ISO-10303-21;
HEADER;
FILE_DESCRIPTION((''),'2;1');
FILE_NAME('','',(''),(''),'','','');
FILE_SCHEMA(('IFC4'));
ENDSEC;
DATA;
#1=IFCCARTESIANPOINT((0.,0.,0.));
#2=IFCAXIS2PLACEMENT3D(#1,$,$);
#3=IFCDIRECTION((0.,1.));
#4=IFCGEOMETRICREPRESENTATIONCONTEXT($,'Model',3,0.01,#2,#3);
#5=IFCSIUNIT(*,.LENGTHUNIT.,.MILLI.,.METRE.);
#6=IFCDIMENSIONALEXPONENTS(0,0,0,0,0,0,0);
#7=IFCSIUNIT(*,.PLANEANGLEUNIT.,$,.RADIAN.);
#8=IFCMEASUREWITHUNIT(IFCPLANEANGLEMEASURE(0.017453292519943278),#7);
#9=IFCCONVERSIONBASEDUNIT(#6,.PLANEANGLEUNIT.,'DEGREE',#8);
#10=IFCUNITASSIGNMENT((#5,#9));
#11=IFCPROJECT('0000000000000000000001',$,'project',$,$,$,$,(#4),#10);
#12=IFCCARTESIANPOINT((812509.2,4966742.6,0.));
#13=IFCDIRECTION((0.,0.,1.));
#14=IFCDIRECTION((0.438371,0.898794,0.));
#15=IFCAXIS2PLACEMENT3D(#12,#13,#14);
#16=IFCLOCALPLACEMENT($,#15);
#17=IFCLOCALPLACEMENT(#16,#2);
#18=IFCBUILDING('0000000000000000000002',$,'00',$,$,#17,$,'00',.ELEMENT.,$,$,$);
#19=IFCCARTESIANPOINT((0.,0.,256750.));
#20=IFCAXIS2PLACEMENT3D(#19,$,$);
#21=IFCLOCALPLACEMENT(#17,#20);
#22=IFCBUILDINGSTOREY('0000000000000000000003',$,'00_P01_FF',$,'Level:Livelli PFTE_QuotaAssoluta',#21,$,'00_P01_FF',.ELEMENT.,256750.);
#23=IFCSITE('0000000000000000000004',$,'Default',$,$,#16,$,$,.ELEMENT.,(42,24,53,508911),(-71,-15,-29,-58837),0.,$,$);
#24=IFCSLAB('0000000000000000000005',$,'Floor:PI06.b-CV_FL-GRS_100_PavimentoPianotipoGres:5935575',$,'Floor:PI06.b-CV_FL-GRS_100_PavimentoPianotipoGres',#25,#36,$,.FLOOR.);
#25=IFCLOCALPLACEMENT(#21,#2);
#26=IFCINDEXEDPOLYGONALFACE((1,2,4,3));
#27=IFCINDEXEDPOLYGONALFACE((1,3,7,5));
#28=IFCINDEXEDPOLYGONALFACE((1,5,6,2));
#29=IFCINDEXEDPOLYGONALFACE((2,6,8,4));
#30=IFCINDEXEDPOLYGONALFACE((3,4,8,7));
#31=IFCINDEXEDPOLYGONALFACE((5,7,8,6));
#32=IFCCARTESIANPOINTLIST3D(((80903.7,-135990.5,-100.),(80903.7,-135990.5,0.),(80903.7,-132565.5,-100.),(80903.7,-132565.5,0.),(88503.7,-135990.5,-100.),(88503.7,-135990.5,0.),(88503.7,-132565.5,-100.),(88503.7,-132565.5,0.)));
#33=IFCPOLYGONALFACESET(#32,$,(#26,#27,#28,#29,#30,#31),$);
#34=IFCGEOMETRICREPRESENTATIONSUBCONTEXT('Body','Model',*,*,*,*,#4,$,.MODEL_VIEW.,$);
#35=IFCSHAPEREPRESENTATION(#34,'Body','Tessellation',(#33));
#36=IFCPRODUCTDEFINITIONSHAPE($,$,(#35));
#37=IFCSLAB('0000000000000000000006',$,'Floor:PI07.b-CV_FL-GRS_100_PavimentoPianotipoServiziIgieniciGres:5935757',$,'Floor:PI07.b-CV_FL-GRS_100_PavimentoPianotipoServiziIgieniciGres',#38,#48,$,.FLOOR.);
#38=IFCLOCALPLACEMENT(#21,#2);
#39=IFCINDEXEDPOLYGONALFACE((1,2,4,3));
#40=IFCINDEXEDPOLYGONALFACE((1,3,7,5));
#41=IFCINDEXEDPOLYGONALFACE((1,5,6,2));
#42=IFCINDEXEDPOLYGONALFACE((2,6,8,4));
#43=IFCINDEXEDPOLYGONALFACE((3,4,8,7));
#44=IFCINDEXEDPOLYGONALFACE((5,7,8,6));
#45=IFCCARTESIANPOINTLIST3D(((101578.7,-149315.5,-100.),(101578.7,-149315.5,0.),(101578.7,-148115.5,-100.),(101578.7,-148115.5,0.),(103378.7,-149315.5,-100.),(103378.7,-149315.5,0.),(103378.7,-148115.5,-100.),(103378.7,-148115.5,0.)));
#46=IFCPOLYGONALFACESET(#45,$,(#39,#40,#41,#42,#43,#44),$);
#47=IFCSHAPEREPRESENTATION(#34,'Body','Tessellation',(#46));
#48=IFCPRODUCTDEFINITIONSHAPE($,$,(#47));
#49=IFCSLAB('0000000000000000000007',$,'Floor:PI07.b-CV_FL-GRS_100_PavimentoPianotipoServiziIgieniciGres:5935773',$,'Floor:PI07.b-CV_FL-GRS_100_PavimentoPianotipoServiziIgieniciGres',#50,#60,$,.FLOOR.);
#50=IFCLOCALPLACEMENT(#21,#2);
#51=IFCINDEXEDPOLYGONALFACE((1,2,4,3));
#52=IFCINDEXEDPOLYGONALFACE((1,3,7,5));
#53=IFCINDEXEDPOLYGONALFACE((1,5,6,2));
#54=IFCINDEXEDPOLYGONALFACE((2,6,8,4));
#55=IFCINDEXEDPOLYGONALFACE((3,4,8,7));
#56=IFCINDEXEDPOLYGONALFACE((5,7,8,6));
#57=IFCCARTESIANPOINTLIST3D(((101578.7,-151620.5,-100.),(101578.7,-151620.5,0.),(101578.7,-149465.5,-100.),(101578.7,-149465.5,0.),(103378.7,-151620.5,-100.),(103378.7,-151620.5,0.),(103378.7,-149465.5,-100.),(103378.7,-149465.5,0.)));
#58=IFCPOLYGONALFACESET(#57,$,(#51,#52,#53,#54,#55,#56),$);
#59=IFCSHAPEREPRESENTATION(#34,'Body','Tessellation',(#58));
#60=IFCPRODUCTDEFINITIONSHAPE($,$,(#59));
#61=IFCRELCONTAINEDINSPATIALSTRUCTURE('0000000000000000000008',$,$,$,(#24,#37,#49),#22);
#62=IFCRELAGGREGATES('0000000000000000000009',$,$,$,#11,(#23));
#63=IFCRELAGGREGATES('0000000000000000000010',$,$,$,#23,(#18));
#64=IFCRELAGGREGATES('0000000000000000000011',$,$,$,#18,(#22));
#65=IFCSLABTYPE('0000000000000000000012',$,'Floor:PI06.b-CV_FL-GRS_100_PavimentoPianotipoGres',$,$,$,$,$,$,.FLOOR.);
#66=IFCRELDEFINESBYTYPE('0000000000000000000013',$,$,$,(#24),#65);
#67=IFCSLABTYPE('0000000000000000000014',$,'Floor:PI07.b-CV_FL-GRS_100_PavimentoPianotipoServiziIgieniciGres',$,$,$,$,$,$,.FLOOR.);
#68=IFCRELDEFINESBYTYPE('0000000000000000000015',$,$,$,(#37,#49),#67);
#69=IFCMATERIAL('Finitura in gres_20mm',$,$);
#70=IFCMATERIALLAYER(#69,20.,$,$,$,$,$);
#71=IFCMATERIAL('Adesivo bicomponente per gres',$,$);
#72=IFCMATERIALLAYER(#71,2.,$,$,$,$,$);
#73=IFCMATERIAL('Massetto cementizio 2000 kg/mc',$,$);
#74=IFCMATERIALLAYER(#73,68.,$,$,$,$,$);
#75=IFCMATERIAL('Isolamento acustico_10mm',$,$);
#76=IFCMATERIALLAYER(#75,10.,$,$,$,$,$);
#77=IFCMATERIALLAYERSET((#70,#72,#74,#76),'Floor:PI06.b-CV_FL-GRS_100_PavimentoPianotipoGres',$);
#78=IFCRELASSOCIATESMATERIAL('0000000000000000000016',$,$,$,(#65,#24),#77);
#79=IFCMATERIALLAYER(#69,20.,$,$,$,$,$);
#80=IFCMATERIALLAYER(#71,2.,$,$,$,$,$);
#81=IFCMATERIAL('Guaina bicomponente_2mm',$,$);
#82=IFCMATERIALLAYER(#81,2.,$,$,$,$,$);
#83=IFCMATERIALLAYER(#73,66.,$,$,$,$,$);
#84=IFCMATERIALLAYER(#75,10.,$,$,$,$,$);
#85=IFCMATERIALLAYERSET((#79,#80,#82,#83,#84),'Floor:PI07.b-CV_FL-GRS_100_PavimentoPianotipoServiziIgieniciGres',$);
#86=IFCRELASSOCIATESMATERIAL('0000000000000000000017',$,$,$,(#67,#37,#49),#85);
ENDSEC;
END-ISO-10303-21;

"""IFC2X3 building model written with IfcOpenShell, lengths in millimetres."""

from ifc_helpers import new_model, entity, si_unit, converted_unit, direction, frame, frame_2d, origin, place, context, subcontext, project, spatial, rectangle, extrude, material, layer, layer_set, layer_usage, type_object, element, save


model = new_model("IFC2X3")

# Units and contexts
model_context = context("Model", 3, precision=0.01, world=origin(), true_north=direction((0.0, 1.0)))
body_context = subcontext(model_context, "Body", "Model", "MODEL_VIEW")
ifc_project = project(units=[si_unit("LENGTHUNIT", "METRE", prefix="MILLI"), converted_unit("PLANEANGLEUNIT", "DEGREE", entity("IfcPlaneAngleMeasure", 0.017453292519943278), si_unit("PLANEANGLEUNIT", "RADIAN"), dimensions=[0, 0, 0, 0, 0, 0, 0])], contexts=[model_context])

# Site, building, storey
site_placement = place(None, frame((812509.2, 4966742.6, 0.0), z_axis=(0.0, 0.0, 1.0), x_axis=(0.438371, 0.898794, 0.0)))
site = spatial("IfcSite", under=ifc_project, at=site_placement, Name="Default", CompositionType="ELEMENT", RefLatitude=(42, 24, 53, 508911), RefLongitude=(-71, -15, -29, -58837), RefElevation=0.0)
building_placement = place(site_placement, origin())
building = spatial("IfcBuilding", under=site, at=building_placement, Name="00", LongName="00", CompositionType="ELEMENT")
storey_placement = place(building_placement, frame((0.0, 0.0, 256750.0)))
storey = spatial("IfcBuildingStorey", under=building, at=storey_placement, Name="00_P01_FF", ObjectType="Level:Livelli PFTE_QuotaAssoluta", LongName="00_P01_FF", CompositionType="ELEMENT", Elevation=256750.0)

# Slab
ifc_material_1 = material(Name="Finitura in gres_20mm")
ifc_layer_1 = layer(ifc_material_1, 20.0)
ifc_material_2 = material(Name="Adesivo bicomponente per gres")
ifc_layer_2 = layer(ifc_material_2, 2.0)
ifc_material_3 = material(Name="Massetto cementizio 2000 kg/mc")
ifc_layer_3 = layer(ifc_material_3, 68.0)
ifc_material_4 = material(Name="Isolamento acustico_10mm")
ifc_layer_4 = layer(ifc_material_4, 10.0)
ifc_layer_set_1 = layer_set([ifc_layer_1, ifc_layer_2, ifc_layer_3, ifc_layer_4], Name="Floor:PI06.b-CV_FL-GRS_100_PavimentoPianotipoGres")
slab_type_1 = type_object("IfcSlabType", Name="Floor:PI06.b-CV_FL-GRS_100_PavimentoPianotipoGres", PredefinedType="FLOOR", material=ifc_layer_set_1)
ifc_layer_usage_1 = layer_usage(ifc_layer_set_1, "AXIS3", "POSITIVE", 0.0)
slab_1_placement = place(storey_placement, origin())
element("IfcSlab", 1, at=slab_1_placement, inside=storey, type_object=slab_type_1, material=ifc_layer_usage_1, Name="Floor:PI06.b-CV_FL-GRS_100_PavimentoPianotipoGres:5935575", ObjectType="Floor:PI06.b-CV_FL-GRS_100_PavimentoPianotipoGres", PredefinedType="FLOOR", context=body_context, shape_type="SweptSolid", body=[
    extrude(rectangle(XDim=7600.0, YDim=3425.0, at=frame_2d((0.0, 0.0), x_axis=(1.0, 0.0))), frame((84703.7, -134278.0, 0.0), z_axis=(0.0, 0.0, -1.0), x_axis=(1.0, 0.0, 0.0)), (0.0, 0.0, 1.0), 100.0),
])

# Slabs
ifc_layer_5 = layer(ifc_material_1, 20.0)
ifc_layer_6 = layer(ifc_material_2, 2.0)
ifc_material_5 = material(Name="Guaina bicomponente_2mm")
ifc_layer_7 = layer(ifc_material_5, 2.0)
ifc_layer_8 = layer(ifc_material_3, 66.0)
ifc_layer_9 = layer(ifc_material_4, 10.0)
ifc_layer_set_2 = layer_set([ifc_layer_5, ifc_layer_6, ifc_layer_7, ifc_layer_8, ifc_layer_9], Name="Floor:PI07.b-CV_FL-GRS_100_PavimentoPianotipoServiziIgieniciGres")
slab_type_2 = type_object("IfcSlabType", Name="Floor:PI07.b-CV_FL-GRS_100_PavimentoPianotipoServiziIgieniciGres", PredefinedType="FLOOR", material=ifc_layer_set_2)
ifc_layer_usage_2 = layer_usage(ifc_layer_set_2, "AXIS3", "POSITIVE", 0.0)
slab_2_placement = place(storey_placement, origin())
element("IfcSlab", 2, at=slab_2_placement, inside=storey, type_object=slab_type_2, material=ifc_layer_usage_2, Name="Floor:PI07.b-CV_FL-GRS_100_PavimentoPianotipoServiziIgieniciGres:5935757", ObjectType="Floor:PI07.b-CV_FL-GRS_100_PavimentoPianotipoServiziIgieniciGres", PredefinedType="FLOOR", context=body_context, shape_type="SweptSolid", body=[
    extrude(rectangle(XDim=1200.0, YDim=1800.0, at=frame_2d((0.0, 0.0), x_axis=(1.0, 0.0))), frame((102478.7, -148715.5, 0.0), z_axis=(0.0, 0.0, -1.0), x_axis=(0.0, 1.0, 0.0)), (0.0, 0.0, 1.0), 100.0),
])
ifc_layer_usage_3 = layer_usage(ifc_layer_set_2, "AXIS3", "POSITIVE", 0.0)
slab_3_placement = place(storey_placement, origin())
element("IfcSlab", 3, at=slab_3_placement, inside=storey, type_object=slab_type_2, material=ifc_layer_usage_3, Name="Floor:PI07.b-CV_FL-GRS_100_PavimentoPianotipoServiziIgieniciGres:5935773", ObjectType="Floor:PI07.b-CV_FL-GRS_100_PavimentoPianotipoServiziIgieniciGres", PredefinedType="FLOOR", context=body_context, shape_type="SweptSolid", body=[
    extrude(rectangle(XDim=2155.0, YDim=1800.0, at=frame_2d((0.0, 0.0), x_axis=(1.0, 0.0))), frame((102478.7, -150543.0, 0.0), z_axis=(0.0, 0.0, -1.0), x_axis=(0.0, 1.0, 0.0)), (0.0, 0.0, 1.0), 100.0),
])

save(model, "model.ifc")
